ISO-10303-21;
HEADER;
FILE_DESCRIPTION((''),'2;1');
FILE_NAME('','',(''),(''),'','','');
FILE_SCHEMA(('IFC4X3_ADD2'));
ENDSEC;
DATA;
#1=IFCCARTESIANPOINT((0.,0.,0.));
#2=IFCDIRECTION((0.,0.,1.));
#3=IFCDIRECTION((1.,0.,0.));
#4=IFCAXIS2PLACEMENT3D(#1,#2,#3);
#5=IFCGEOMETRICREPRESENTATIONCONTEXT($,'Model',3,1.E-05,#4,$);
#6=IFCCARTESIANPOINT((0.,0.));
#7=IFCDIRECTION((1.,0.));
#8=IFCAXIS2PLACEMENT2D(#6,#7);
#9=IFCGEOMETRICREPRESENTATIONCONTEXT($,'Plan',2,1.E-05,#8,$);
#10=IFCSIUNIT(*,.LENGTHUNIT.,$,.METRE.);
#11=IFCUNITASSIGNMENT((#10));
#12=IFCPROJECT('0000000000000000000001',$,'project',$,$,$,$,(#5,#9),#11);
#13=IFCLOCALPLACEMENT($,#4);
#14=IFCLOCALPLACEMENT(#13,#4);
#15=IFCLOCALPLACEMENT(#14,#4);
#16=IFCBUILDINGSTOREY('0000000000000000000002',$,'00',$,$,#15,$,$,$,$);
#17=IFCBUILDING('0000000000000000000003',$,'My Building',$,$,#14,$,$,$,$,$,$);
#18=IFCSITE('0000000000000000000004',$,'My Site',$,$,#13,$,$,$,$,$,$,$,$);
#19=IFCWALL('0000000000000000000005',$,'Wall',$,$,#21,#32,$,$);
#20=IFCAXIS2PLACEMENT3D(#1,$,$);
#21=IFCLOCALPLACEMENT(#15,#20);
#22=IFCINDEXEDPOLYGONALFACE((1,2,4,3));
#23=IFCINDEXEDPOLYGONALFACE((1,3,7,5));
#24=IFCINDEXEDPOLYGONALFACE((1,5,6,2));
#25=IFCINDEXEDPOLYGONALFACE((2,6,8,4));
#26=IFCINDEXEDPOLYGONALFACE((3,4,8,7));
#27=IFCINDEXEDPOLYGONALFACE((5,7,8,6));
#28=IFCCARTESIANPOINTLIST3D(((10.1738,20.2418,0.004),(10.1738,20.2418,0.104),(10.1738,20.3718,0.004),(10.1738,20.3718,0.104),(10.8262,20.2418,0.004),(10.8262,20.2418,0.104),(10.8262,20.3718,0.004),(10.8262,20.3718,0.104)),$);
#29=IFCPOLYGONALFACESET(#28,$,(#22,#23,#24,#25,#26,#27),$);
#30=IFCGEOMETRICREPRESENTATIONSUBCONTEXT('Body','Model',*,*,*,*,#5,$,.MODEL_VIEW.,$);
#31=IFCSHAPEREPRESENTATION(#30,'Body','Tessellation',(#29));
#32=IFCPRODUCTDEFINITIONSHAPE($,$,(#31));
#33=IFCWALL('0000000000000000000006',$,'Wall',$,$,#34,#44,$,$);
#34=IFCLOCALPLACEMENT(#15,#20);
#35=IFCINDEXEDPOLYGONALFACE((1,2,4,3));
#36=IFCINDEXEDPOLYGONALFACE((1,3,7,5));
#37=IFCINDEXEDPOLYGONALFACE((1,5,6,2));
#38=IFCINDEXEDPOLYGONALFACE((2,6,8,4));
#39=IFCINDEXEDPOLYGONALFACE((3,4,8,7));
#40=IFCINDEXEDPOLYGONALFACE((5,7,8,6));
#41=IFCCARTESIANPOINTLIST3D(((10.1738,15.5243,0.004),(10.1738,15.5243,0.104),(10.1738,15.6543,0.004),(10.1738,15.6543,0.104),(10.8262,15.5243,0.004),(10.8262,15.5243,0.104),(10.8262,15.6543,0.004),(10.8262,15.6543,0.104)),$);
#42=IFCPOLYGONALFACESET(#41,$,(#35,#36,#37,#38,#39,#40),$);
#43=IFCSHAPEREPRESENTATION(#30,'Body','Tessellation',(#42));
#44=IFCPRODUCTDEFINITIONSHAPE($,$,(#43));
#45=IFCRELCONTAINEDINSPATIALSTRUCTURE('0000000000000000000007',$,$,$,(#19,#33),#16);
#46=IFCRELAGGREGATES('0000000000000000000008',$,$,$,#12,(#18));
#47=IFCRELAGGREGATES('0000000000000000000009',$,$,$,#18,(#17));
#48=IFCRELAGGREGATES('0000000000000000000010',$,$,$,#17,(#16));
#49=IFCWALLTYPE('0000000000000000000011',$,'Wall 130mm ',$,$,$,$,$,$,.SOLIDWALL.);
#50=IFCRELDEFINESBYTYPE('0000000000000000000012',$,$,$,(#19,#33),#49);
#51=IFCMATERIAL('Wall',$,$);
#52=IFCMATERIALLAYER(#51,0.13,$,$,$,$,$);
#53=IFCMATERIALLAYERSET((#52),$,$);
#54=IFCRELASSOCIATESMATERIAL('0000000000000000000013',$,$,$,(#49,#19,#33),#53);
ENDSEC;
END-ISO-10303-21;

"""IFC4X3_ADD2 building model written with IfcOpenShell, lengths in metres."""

from ifc_helpers import new_model, si_unit, frame, origin_with_axes, origin_2d_with_axis, place, context, subcontext, project, spatial, indexed_curve, outline, extrude, material, layer, layer_set, layer_usage, type_object, element, save


model = new_model("IFC4X3_ADD2")

# Units and contexts
model_context = context("Model", 3, precision=1e-05, world=origin_with_axes())
plan_context = context("Plan", 2, precision=1e-05, world=origin_2d_with_axis())
body_context = subcontext(model_context, "Body", "Model", "MODEL_VIEW")
ifc_project = project(units=[si_unit("LENGTHUNIT", "METRE")], contexts=[model_context, plan_context])

# Site, building, storey
site_placement = place(None, origin_with_axes())
site = spatial("IfcSite", under=ifc_project, at=site_placement, Name="My Site")
building_placement = place(site_placement, origin_with_axes())
building = spatial("IfcBuilding", under=site, at=building_placement, Name="My Building")
storey_placement = place(building_placement, origin_with_axes())
storey = spatial("IfcBuildingStorey", under=building, at=storey_placement, Name="00")

# Walls
ifc_material_1 = material(Name="Wall")
ifc_layer_1 = layer(ifc_material_1, 0.13)
ifc_layer_set_1 = layer_set([ifc_layer_1])
wall_type_1 = type_object("IfcWallType", Name="Wall 130mm ", PredefinedType="SOLIDWALL", material=ifc_layer_set_1)
ifc_layer_usage_1 = layer_usage(ifc_layer_set_1, "AXIS2", "POSITIVE", 0.0)
wall_1_placement = place(storey_placement, frame((10.8262, 20.3718, 0.004), z_axis=(0.0, 0.0, 1.0), x_axis=(-1.0, 0.000001, 0.0)))
element("IfcWall", 1, at=wall_1_placement, inside=storey, type_object=wall_type_1, material=ifc_layer_usage_1, Name="Wall", context=body_context, shape_type="SweptSolid", body=[
    extrude(outline(indexed_curve([(0.0, 0.0), (0.0, 0.13), (0.6524, 0.13), (0.6524, 0.0), (0.0, 0.0)], self_intersect=False)), origin_with_axes(), (0.0, 0.0, 1.0), 0.1),
])
ifc_layer_usage_2 = layer_usage(ifc_layer_set_1, "AXIS2", "POSITIVE", 0.0)
wall_2_placement = place(storey_placement, frame((10.8262, 15.6543, 0.004), z_axis=(0.0, 0.0, 1.0), x_axis=(-1.0, 0.000001, 0.0)))
element("IfcWall", 2, at=wall_2_placement, inside=storey, type_object=wall_type_1, material=ifc_layer_usage_2, Name="Wall", context=body_context, shape_type="SweptSolid", body=[
    extrude(outline(indexed_curve([(0.0, 0.0), (0.0, 0.13), (0.6524, 0.13), (0.6524, 0.0), (0.0, 0.0)], self_intersect=False)), origin_with_axes(), (0.0, 0.0, 1.0), 0.1),
])

save(model, "model.ifc")
